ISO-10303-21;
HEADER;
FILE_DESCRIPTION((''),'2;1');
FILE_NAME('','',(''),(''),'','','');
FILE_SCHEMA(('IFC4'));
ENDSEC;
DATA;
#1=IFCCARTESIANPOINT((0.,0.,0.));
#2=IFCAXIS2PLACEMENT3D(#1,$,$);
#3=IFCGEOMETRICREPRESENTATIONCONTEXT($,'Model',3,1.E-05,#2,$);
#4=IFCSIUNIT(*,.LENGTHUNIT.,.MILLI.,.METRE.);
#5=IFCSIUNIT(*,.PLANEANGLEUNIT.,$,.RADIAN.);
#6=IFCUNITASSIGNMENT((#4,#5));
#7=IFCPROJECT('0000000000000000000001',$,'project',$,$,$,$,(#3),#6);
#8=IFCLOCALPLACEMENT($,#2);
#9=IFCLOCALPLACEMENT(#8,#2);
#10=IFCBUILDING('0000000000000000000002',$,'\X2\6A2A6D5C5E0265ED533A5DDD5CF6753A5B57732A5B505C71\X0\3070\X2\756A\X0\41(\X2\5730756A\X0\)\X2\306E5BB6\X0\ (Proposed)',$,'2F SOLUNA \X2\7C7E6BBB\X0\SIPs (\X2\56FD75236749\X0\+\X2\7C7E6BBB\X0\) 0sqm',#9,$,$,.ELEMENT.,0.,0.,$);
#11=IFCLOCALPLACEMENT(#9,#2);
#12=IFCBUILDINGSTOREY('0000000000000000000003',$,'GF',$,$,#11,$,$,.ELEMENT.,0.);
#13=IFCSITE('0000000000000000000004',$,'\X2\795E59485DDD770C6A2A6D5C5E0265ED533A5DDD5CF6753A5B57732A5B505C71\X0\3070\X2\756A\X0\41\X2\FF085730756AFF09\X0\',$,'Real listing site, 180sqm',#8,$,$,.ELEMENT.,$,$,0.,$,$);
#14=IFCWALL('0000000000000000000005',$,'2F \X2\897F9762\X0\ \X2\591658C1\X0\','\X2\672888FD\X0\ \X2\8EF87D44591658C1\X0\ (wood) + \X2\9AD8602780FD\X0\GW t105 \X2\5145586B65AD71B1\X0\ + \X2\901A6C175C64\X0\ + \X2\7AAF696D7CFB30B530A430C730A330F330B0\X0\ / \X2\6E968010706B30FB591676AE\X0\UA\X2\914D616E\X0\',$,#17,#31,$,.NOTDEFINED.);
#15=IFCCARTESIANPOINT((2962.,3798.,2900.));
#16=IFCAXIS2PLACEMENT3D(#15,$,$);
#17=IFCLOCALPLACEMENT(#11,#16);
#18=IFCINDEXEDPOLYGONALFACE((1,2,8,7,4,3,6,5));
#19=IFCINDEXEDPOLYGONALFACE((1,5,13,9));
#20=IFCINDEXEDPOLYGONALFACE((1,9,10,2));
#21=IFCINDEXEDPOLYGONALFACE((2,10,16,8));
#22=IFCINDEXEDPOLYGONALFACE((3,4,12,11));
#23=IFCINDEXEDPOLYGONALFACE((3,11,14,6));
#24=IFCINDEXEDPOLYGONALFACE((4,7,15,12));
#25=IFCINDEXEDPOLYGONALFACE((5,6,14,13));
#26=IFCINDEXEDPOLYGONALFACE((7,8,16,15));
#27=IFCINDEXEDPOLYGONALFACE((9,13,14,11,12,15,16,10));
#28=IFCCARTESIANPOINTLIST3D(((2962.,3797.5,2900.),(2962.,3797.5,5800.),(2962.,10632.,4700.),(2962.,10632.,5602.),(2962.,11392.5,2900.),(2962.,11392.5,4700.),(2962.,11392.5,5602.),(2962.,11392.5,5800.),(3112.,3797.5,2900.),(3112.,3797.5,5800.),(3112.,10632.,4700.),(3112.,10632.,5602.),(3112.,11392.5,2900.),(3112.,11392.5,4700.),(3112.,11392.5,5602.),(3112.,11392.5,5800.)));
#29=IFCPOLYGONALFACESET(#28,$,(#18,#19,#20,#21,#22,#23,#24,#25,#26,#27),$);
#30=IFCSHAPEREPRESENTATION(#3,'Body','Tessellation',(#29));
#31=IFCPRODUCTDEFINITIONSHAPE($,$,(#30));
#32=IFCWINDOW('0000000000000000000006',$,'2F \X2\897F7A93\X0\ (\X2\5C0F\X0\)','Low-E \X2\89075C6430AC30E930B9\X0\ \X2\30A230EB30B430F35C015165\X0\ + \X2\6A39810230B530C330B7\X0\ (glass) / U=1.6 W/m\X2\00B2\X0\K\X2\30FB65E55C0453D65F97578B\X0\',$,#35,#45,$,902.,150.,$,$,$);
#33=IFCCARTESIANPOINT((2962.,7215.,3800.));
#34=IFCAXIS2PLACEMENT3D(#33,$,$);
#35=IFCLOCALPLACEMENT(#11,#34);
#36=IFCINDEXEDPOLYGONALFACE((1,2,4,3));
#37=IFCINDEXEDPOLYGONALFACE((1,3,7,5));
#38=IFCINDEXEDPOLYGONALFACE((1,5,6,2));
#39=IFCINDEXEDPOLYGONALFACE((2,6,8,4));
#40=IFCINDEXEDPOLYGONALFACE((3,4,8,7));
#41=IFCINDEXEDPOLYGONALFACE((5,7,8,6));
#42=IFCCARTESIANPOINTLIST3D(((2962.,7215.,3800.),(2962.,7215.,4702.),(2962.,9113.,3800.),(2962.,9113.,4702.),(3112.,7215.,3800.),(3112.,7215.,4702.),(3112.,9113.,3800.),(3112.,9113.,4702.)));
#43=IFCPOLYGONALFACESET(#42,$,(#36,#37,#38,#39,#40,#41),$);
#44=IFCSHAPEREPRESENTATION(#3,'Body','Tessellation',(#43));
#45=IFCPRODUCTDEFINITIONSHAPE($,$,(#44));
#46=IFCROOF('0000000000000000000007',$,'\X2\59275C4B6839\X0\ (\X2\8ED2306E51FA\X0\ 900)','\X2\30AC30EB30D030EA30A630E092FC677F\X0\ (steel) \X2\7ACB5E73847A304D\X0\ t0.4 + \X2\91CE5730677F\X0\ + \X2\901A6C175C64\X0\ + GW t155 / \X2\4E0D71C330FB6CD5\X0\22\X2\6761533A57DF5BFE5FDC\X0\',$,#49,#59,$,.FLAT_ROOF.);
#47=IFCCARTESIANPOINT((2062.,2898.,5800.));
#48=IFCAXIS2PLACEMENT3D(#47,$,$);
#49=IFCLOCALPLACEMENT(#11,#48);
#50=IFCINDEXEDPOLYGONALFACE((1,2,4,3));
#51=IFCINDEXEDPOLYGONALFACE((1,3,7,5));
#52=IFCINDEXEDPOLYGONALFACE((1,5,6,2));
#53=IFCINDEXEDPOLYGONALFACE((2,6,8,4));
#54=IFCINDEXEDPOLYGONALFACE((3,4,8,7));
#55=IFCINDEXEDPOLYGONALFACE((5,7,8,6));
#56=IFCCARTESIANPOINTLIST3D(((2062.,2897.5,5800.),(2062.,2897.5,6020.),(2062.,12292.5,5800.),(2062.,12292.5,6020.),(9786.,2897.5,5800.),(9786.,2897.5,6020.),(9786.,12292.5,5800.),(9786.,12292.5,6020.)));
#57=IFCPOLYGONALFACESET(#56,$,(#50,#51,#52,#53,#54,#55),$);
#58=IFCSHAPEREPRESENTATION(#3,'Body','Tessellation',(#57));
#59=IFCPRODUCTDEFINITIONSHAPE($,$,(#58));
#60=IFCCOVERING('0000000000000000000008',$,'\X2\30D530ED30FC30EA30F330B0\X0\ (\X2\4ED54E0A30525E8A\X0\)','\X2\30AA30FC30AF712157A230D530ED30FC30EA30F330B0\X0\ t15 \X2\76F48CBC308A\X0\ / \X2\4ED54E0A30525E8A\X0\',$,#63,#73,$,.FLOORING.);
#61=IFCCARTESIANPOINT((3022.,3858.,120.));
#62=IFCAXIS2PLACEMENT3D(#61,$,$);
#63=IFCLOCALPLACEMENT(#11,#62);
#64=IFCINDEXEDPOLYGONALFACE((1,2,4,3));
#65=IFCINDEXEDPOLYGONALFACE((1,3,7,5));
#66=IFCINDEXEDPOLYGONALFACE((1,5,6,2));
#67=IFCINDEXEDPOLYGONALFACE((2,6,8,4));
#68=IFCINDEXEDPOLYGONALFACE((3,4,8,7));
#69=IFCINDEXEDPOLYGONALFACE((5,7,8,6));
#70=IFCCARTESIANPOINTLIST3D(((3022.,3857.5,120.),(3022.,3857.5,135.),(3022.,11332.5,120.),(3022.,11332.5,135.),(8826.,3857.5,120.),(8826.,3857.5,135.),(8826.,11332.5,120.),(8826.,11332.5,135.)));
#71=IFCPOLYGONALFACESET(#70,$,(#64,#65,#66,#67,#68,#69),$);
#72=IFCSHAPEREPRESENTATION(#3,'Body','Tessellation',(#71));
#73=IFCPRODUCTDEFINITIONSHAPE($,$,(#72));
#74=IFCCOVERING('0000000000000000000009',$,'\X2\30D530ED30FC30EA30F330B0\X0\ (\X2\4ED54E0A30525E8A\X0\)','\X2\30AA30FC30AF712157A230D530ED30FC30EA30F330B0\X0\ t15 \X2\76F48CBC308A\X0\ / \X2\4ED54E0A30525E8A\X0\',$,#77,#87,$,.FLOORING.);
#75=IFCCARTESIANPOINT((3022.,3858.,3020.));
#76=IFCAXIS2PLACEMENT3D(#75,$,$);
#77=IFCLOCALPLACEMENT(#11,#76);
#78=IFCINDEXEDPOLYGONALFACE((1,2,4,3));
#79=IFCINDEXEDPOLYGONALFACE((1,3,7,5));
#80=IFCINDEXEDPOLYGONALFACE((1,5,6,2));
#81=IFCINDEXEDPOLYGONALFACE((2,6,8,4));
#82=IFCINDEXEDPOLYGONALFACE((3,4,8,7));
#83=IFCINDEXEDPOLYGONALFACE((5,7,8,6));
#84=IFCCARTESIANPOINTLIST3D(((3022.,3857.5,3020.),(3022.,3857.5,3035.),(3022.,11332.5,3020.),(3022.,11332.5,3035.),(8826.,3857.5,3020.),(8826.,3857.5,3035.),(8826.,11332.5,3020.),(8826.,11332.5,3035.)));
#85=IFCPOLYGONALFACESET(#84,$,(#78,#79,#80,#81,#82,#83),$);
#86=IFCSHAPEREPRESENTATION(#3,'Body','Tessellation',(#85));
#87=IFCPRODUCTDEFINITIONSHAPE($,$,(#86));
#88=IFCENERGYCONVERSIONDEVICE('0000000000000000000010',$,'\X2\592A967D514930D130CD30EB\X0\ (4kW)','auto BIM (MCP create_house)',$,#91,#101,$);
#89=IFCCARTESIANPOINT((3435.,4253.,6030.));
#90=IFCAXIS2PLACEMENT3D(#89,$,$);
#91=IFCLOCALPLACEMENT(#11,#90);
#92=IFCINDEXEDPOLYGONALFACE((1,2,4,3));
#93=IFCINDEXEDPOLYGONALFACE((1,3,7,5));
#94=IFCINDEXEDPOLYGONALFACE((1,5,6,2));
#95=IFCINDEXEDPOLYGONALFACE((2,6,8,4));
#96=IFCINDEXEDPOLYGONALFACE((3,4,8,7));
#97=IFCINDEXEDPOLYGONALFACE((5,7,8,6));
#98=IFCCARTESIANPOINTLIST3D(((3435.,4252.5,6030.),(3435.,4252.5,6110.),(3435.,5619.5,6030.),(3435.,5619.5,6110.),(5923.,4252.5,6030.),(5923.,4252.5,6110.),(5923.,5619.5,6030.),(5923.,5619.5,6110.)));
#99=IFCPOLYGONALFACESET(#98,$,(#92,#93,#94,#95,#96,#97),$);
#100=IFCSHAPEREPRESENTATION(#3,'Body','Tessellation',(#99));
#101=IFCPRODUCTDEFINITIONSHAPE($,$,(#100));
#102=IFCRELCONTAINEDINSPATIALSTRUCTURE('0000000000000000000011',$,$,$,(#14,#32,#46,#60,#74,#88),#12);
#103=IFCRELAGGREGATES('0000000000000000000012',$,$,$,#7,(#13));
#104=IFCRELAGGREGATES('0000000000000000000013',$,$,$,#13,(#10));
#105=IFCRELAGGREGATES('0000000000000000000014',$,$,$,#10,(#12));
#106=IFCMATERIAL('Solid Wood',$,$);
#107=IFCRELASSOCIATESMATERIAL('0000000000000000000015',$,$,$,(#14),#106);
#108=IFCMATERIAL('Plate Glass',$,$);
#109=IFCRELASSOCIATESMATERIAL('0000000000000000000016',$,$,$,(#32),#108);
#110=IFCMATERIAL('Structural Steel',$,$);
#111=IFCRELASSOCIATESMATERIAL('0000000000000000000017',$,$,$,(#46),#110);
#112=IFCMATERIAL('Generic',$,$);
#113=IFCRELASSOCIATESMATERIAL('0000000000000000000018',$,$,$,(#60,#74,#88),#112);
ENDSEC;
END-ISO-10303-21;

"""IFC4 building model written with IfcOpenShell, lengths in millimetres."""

from ifc_helpers import new_model, si_unit, frame, frame_2d, origin, place, context, project, spatial, rectangle, extrude, material, element, fill, save


model = new_model("IFC4")

# Units and contexts
model_context = context("Model", 3, precision=1e-05, world=origin())
ifc_project = project(units=[si_unit("LENGTHUNIT", "METRE", prefix="MILLI"), si_unit("PLANEANGLEUNIT", "RADIAN")], contexts=[model_context])

# Site, building, storey
site_placement = place(None, origin())
site = spatial("IfcSite", under=ifc_project, at=site_placement, Name="神奈川県横浜市旭区川島町字猪子山3070番41（地番）", ObjectType="Real listing site, 180sqm", CompositionType="ELEMENT", RefElevation=0.0)
building_placement = place(site_placement, origin())
building = spatial("IfcBuilding", under=site, at=building_placement, Name="横浜市旭区川島町字猪子山3070番41(地番)の家 (Proposed)", ObjectType="2F SOLUNA 籾殻SIPs (国産杉+籾殻) 0sqm", CompositionType="ELEMENT", ElevationOfRefHeight=0.0, ElevationOfTerrain=0.0)
storey_placement = place(building_placement, origin())
storey = spatial("IfcBuildingStorey", under=building, at=storey_placement, Name="GF", CompositionType="ELEMENT", Elevation=0.0)

# Shared definitions
ifc_material_1 = material(Name="Solid Wood")

# Shared definitions
ifc_material_2 = material(Name="Plate Glass")

# Wall, opening, window
wall_1_placement = place(storey_placement, frame((2962.0, 3798.0, 2900.0)))
wall_1 = element("IfcWall", 1, at=wall_1_placement, inside=storey, material=ifc_material_1, Name="2F 西面 外壁", Description="木製 軸組外壁 (wood) + 高性能GW t105 充填断熱 + 通気層 + 窯業系サイディング / 準耐火・外皮UA配慮", PredefinedType="NOTDEFINED", context=model_context, shape_type="SweptSolid", body=[
    extrude(rectangle(XDim=150.0, YDim=7595.0, at=frame_2d((75.0, 3797.0))), frame((2962.0, 3798.0, 2900.0)), (0.0, 0.0, 1.0), 2900.0),
])
opening_1_placement = place(storey_placement, frame((2962.0, 7215.0, 3800.0)))
opening_1 = element("IfcOpeningElement", 2, at=opening_1_placement, cuts=wall_1, PredefinedType="NOTDEFINED", context=model_context, shape_type="SweptSolid", body=[
    extrude(rectangle(XDim=150.0, YDim=1898.0, at=frame_2d((75.0, 949.0))), frame((2962.0, 7215.0, 3800.0)), (0.0, 0.0, 1.0), 902.0),
])
window_1_placement = place(storey_placement, frame((2962.0, 7215.0, 3800.0)))
window_1 = element("IfcWindow", 3, at=window_1_placement, inside=storey, material=ifc_material_2, Name="2F 西窓 (小)", Description="Low-E 複層ガラス アルゴン封入 + 樹脂サッシ (glass) / U=1.6 W/m²K・日射取得型", OverallHeight=902.0, OverallWidth=150.0, context=model_context, shape_type="SweptSolid", body=[
    extrude(rectangle(XDim=150.0, YDim=1898.0, at=frame_2d((75.0, 949.0))), frame((2962.0, 7215.0, 3800.0)), (0.0, 0.0, 1.0), 902.0),
])
fill(opening_1, window_1)

# Roof
ifc_material_3 = material(Name="Structural Steel")
roof_placement = place(storey_placement, frame((2062.0, 2898.0, 5800.0)))
element("IfcRoof", 4, at=roof_placement, inside=storey, material=ifc_material_3, Name="大屋根 (軒の出 900)", Description="ガルバリウム鋼板 (steel) 立平葺き t0.4 + 野地板 + 通気層 + GW t155 / 不燃・法22条区域対応", PredefinedType="FLAT_ROOF", context=model_context, shape_type="SweptSolid", body=[
    extrude(rectangle(XDim=7724.0, YDim=9395.0, at=frame_2d((3862.0, 4697.0))), frame((2062.0, 2898.0, 5800.0)), (0.0, 0.0, 1.0), 220.0),
])

# Coverings
ifc_material_4 = material(Name="Generic")
covering_1_placement = place(storey_placement, frame((3022.0, 3858.0, 120.0)))
element("IfcCovering", 5, at=covering_1_placement, inside=storey, material=ifc_material_4, Name="フローリング (仕上げ床)", Description="オーク無垢フローリング t15 直貼り / 仕上げ床", PredefinedType="FLOORING", context=model_context, shape_type="SweptSolid", body=[
    extrude(rectangle(XDim=5804.0, YDim=7475.0, at=frame_2d((2902.0, 3737.0))), frame((3022.0, 3858.0, 120.0)), (0.0, 0.0, 1.0), 15.0),
])
covering_2_placement = place(storey_placement, frame((3022.0, 3858.0, 3020.0)))
element("IfcCovering", 6, at=covering_2_placement, inside=storey, material=ifc_material_4, Name="フローリング (仕上げ床)", Description="オーク無垢フローリング t15 直貼り / 仕上げ床", PredefinedType="FLOORING", context=model_context, shape_type="SweptSolid", body=[
    extrude(rectangle(XDim=5804.0, YDim=7475.0, at=frame_2d((2902.0, 3737.0))), frame((3022.0, 3858.0, 3020.0)), (0.0, 0.0, 1.0), 15.0),
])

# Energy conversion device
energy_conversion_device_placement = place(storey_placement, frame((3435.0, 4253.0, 6030.0)))
element("IfcEnergyConversionDevice", 7, at=energy_conversion_device_placement, inside=storey, material=ifc_material_4, Name="太陽光パネル (4kW)", Description="auto BIM (MCP create_house)", context=model_context, shape_type="SweptSolid", body=[
    extrude(rectangle(XDim=2488.0, YDim=1367.0, at=frame_2d((1244.0, 683.0))), frame((3435.0, 4253.0, 6030.0)), (0.0, 0.0, 1.0), 80.0),
])

save(model, "model.ifc")
